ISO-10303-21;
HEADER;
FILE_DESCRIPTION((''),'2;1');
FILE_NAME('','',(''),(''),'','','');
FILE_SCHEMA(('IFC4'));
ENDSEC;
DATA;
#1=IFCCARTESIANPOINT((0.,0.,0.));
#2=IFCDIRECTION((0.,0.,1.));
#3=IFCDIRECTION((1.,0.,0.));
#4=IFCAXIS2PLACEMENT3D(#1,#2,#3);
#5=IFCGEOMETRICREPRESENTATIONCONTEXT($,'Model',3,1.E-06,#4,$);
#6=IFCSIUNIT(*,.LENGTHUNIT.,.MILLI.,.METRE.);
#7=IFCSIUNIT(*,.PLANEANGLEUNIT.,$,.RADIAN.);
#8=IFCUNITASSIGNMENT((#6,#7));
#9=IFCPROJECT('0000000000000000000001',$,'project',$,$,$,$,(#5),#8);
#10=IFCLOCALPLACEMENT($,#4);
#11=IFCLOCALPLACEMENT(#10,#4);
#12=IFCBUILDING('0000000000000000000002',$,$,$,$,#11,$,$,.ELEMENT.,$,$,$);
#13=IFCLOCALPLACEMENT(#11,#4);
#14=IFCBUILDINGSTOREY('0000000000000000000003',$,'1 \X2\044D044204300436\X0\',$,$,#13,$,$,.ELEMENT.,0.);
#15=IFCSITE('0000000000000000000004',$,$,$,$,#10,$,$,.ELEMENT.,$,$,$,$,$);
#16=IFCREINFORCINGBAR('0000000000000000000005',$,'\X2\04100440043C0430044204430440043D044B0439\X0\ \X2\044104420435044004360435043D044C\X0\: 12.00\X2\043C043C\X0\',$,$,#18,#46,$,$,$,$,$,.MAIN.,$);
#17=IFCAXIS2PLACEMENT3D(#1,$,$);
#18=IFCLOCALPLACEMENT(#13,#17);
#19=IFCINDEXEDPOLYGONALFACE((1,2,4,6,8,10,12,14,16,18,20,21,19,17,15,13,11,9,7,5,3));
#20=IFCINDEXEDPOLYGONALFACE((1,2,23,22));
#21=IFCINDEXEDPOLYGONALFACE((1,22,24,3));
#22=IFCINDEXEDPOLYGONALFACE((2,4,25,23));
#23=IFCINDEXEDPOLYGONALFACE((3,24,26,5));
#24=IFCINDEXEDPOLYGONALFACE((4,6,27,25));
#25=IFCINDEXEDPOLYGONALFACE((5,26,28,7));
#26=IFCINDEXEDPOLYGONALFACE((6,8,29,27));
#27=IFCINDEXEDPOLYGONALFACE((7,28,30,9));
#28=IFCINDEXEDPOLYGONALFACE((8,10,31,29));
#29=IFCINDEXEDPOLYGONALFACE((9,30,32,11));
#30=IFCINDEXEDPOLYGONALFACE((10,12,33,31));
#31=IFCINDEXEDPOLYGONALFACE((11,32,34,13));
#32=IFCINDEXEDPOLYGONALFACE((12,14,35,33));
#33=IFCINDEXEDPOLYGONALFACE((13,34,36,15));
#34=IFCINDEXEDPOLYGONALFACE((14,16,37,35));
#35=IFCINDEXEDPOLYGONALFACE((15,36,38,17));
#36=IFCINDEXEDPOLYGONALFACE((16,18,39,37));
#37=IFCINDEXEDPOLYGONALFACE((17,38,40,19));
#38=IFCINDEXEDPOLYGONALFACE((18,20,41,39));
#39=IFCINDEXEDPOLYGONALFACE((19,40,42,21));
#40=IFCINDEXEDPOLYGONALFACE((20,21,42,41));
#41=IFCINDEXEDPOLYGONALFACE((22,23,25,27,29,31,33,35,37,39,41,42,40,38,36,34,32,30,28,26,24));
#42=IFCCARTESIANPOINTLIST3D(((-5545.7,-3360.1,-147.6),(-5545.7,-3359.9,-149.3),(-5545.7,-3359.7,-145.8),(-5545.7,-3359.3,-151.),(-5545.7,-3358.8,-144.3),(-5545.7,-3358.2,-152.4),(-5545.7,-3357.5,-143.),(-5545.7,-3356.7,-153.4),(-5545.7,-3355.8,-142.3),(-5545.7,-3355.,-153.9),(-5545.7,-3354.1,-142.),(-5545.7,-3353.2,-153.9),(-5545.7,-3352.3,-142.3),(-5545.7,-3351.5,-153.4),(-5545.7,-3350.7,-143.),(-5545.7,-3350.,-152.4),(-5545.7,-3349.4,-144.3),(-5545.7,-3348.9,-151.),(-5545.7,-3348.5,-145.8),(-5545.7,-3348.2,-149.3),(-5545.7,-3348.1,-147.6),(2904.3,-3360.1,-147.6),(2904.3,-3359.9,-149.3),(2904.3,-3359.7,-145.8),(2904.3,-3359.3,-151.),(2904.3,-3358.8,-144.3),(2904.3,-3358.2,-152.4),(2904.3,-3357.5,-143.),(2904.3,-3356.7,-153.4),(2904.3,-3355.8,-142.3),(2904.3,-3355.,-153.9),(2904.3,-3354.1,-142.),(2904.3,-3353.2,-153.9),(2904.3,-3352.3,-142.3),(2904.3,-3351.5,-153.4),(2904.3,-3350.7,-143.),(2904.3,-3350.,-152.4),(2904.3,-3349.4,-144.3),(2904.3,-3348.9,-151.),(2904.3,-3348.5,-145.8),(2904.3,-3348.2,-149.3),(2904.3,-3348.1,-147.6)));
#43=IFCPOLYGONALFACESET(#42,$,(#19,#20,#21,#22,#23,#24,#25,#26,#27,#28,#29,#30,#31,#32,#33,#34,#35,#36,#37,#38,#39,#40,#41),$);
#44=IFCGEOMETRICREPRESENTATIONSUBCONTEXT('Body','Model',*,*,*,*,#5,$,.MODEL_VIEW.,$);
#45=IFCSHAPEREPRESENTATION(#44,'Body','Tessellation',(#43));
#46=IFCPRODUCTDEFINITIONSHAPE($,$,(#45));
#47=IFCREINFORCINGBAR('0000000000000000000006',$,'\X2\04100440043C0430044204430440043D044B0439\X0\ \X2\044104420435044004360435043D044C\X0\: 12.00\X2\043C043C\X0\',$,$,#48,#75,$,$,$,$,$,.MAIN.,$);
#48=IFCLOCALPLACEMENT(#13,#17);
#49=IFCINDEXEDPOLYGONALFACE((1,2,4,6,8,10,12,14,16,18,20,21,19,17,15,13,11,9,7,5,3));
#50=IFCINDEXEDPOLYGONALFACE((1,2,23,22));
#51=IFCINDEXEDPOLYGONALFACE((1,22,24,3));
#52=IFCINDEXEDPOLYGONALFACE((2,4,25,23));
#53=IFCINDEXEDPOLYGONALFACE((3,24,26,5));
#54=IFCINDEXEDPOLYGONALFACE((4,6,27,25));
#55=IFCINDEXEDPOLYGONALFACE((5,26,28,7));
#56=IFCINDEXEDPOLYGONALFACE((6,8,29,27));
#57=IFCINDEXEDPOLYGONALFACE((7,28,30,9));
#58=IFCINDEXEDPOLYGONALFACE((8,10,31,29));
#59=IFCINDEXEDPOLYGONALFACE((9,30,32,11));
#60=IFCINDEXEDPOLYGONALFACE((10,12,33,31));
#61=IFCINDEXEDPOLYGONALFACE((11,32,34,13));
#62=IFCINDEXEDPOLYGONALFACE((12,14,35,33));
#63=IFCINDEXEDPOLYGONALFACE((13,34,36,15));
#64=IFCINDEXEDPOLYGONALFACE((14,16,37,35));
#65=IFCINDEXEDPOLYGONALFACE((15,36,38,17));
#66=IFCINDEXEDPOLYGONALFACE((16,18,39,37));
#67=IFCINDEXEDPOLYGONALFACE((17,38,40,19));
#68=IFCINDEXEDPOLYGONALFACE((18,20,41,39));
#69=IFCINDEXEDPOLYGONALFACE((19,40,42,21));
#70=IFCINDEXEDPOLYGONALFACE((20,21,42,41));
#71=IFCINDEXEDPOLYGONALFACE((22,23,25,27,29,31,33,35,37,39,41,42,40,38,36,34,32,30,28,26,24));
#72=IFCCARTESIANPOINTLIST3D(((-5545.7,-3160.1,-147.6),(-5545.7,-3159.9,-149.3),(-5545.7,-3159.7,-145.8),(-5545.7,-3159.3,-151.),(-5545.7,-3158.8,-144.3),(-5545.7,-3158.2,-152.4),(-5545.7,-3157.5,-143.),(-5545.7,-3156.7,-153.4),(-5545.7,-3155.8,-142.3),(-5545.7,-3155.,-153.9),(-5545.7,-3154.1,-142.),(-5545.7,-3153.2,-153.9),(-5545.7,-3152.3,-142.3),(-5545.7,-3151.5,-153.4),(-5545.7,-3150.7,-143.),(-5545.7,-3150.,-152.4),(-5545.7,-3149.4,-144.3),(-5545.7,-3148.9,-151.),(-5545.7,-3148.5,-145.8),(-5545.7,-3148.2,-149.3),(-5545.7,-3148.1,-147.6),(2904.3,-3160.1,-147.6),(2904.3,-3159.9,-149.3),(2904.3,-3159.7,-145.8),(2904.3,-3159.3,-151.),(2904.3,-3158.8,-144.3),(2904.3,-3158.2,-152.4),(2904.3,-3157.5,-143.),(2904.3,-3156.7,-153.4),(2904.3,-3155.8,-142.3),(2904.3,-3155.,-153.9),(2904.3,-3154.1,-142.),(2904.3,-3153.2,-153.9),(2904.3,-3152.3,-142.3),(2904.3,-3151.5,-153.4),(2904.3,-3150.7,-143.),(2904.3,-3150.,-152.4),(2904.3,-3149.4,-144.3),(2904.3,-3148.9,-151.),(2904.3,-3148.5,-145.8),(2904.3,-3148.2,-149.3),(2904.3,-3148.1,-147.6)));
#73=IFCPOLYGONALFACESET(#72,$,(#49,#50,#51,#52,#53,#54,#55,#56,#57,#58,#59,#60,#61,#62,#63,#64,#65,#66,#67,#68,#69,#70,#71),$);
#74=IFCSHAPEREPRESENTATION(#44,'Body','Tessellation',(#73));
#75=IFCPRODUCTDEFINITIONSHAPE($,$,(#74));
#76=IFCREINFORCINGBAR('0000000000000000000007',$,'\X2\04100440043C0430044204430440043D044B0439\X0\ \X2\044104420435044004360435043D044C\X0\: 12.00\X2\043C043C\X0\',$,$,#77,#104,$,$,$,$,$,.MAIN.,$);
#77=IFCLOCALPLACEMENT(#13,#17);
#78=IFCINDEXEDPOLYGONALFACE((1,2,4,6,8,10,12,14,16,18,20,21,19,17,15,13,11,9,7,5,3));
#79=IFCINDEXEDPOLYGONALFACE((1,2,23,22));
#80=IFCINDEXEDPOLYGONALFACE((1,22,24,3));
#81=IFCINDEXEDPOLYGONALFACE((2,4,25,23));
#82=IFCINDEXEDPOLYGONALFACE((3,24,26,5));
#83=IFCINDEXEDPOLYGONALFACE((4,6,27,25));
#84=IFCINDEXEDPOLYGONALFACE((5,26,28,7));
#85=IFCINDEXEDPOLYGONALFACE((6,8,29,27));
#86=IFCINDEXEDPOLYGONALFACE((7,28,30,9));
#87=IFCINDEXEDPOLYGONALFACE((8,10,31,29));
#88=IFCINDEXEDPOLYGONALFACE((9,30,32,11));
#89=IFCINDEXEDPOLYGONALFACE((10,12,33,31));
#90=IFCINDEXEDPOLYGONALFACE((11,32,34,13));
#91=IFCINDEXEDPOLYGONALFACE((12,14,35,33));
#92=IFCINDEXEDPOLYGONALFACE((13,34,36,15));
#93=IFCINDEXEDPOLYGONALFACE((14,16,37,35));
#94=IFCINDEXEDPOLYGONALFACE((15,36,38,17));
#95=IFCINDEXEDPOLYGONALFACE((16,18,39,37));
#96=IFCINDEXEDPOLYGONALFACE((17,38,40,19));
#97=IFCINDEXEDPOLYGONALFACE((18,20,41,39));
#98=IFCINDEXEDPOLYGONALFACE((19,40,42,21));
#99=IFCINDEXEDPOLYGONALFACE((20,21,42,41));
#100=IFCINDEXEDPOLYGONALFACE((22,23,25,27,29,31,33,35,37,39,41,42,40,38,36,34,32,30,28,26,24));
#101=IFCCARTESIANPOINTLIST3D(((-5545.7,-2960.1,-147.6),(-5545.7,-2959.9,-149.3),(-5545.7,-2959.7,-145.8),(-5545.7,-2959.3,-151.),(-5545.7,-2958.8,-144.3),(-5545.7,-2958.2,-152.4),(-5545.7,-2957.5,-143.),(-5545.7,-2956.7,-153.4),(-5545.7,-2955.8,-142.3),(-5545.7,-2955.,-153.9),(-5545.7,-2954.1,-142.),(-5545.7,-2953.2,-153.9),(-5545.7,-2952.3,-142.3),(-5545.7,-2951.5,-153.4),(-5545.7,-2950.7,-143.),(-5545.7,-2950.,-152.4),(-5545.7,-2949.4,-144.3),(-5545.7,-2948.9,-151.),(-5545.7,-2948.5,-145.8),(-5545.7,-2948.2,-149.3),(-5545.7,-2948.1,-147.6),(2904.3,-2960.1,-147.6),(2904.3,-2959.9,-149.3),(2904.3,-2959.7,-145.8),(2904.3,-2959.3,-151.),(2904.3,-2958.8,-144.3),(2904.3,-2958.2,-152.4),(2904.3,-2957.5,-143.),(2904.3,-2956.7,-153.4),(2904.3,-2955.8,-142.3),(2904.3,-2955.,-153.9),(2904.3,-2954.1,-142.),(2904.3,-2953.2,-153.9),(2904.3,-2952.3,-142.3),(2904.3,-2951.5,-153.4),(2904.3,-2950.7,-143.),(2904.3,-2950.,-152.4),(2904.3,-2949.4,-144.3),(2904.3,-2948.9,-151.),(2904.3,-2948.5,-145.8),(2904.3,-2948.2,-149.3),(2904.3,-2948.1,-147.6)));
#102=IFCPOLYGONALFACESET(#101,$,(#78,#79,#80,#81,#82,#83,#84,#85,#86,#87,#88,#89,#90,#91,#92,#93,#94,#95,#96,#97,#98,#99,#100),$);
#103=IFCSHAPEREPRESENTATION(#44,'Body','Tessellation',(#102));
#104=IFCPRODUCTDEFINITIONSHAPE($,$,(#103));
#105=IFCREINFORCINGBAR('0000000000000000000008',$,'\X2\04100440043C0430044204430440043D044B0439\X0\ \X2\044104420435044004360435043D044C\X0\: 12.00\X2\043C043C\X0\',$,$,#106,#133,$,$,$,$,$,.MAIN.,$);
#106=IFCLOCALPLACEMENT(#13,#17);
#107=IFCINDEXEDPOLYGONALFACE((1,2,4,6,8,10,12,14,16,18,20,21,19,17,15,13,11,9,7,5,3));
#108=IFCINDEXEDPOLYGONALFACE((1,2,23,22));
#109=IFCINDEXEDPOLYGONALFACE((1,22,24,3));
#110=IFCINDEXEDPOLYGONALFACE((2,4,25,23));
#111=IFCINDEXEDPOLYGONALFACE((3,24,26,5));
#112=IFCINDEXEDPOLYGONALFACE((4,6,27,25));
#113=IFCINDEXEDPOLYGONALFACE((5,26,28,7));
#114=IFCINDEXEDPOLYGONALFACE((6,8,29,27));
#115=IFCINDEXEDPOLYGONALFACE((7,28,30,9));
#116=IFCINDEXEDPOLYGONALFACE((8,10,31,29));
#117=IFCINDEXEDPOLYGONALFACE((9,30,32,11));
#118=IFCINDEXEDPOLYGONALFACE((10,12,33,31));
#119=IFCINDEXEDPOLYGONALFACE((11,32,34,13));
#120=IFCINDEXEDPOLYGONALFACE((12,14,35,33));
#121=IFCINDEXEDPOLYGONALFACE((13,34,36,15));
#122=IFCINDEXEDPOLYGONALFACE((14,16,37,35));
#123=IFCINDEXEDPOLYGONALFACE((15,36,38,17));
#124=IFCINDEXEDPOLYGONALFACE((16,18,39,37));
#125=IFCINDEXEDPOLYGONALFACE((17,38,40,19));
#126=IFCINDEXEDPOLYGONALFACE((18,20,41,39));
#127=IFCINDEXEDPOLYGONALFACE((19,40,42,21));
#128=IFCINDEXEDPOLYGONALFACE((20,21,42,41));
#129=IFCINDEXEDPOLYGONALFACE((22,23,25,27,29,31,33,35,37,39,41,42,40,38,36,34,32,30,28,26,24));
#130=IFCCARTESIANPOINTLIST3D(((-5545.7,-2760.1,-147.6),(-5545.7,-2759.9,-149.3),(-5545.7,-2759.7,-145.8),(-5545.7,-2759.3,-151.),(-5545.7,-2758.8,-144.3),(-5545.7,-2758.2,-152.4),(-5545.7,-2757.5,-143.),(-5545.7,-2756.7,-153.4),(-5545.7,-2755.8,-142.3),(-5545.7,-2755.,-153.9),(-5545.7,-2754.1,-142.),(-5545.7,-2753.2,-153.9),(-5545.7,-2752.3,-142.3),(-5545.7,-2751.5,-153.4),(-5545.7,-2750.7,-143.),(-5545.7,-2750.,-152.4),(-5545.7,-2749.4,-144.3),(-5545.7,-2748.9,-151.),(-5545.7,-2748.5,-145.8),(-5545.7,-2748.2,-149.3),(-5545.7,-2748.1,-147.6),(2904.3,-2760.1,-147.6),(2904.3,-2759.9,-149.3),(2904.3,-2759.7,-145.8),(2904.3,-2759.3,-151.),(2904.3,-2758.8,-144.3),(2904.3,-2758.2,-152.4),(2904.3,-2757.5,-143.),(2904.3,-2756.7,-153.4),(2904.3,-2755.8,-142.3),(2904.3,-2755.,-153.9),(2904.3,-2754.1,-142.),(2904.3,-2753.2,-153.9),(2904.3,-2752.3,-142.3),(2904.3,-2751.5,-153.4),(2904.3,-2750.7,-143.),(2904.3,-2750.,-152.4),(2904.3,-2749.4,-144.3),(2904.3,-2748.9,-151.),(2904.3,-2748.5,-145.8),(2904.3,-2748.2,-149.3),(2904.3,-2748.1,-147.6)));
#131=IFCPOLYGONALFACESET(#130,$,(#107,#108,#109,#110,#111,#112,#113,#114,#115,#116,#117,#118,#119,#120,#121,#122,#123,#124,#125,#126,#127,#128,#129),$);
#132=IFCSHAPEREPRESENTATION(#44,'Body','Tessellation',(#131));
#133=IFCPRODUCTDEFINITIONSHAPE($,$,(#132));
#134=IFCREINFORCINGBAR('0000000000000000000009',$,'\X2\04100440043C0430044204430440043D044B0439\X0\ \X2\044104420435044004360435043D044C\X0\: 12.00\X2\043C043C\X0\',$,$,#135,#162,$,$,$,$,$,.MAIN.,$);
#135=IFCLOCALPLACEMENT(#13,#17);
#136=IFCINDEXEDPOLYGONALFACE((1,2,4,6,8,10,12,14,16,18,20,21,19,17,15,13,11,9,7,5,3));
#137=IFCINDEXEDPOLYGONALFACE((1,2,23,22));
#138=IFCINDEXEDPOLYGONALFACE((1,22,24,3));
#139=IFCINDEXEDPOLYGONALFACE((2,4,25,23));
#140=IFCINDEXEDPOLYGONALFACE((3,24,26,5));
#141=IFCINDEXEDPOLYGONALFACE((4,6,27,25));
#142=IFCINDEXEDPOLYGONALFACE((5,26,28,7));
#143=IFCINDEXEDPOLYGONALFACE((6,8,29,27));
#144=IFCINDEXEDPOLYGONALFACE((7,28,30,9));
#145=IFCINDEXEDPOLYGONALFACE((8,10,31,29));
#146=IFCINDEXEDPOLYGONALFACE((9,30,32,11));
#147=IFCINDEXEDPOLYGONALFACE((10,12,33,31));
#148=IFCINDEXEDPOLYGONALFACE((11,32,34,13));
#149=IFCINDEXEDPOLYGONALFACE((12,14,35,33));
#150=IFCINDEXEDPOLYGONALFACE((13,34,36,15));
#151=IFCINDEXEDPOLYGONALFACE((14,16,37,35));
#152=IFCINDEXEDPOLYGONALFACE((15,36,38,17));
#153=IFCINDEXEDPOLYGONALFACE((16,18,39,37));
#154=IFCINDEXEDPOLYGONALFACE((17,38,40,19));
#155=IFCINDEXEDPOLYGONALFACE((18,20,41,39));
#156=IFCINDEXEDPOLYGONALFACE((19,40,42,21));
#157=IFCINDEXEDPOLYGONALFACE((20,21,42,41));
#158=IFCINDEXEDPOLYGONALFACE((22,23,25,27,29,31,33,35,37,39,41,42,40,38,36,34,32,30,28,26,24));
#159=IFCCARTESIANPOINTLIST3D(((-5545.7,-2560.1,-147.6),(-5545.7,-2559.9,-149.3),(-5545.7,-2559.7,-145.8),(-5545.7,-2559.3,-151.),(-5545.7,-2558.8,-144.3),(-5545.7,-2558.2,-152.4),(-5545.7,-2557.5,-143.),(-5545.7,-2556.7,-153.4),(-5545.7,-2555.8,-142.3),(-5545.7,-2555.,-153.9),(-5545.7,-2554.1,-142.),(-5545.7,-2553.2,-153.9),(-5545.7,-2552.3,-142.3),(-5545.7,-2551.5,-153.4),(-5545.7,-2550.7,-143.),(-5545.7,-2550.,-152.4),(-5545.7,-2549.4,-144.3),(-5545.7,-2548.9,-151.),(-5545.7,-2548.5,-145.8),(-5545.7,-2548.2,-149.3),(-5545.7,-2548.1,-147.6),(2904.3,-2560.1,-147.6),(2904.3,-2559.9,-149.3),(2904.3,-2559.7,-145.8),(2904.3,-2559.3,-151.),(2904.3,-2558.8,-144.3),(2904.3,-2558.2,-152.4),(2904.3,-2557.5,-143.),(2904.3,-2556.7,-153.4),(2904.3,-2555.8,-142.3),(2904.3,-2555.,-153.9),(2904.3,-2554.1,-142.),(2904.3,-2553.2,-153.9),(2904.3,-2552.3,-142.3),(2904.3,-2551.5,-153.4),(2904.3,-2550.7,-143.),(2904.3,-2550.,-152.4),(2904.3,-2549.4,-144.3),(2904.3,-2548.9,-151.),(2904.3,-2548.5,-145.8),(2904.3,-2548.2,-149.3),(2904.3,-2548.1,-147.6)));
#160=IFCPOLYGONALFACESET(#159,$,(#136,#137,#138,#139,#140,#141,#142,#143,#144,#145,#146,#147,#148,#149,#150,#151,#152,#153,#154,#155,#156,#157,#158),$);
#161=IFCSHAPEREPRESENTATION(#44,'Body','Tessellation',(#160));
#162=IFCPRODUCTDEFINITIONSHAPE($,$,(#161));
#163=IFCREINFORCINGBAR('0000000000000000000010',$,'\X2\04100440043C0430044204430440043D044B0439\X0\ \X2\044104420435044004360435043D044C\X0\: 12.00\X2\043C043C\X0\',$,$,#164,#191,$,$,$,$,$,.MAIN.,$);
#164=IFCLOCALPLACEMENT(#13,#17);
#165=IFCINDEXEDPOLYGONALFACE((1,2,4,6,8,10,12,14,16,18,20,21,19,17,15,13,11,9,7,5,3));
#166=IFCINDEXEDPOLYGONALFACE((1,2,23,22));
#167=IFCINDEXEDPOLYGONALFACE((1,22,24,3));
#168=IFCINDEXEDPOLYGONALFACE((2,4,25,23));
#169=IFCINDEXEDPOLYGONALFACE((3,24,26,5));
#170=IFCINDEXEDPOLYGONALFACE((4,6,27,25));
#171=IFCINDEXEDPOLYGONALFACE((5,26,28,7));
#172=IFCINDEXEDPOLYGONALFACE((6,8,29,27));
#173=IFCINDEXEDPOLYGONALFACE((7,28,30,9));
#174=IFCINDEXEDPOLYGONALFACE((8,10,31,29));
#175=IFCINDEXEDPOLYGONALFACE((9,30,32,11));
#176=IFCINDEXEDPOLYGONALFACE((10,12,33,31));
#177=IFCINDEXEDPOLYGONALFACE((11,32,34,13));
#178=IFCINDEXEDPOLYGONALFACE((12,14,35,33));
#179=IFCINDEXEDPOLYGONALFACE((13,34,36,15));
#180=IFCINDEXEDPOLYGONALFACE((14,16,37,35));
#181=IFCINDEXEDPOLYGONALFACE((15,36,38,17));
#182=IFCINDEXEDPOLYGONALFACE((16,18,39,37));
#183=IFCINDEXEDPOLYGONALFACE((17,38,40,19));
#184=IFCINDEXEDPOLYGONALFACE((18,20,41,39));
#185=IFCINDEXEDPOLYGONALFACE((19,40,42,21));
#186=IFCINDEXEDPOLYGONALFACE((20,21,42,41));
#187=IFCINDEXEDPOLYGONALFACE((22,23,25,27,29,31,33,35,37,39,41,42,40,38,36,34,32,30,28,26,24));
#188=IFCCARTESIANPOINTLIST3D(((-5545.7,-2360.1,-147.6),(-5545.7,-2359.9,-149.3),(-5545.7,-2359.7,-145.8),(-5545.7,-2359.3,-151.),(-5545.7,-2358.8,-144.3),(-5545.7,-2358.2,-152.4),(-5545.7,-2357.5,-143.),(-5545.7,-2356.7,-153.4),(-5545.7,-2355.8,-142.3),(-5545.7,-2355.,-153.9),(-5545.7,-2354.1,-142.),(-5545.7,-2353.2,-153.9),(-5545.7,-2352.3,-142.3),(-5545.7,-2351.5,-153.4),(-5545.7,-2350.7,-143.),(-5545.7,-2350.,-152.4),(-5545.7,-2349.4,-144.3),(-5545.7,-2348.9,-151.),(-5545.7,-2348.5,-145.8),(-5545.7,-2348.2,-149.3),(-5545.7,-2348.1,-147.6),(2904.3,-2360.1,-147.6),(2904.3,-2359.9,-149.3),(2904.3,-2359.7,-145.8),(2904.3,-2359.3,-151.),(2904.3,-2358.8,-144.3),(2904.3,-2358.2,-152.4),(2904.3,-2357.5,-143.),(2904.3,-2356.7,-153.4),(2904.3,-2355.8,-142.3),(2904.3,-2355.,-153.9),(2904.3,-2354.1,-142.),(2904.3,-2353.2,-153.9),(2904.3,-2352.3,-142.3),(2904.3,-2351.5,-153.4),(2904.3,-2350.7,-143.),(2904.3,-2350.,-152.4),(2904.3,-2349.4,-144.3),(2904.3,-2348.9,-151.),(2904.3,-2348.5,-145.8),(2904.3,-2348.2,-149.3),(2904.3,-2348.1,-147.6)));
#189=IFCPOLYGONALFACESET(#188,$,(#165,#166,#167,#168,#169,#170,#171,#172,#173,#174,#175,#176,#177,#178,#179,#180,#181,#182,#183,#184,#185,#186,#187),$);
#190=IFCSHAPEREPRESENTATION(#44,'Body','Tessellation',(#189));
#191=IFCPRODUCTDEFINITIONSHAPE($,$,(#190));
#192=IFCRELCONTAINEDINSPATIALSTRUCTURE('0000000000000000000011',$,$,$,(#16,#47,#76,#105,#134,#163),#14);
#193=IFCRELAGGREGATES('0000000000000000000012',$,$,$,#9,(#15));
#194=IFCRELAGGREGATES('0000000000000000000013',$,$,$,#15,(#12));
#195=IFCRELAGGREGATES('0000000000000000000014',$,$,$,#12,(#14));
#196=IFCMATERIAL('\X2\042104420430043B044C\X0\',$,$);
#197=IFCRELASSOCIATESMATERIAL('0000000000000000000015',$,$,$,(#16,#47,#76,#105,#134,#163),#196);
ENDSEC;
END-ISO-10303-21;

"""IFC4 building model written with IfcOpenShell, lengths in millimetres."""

from ifc_helpers import new_model, entity, si_unit, origin_with_axes, place, context, subcontext, project, spatial, source, transform, mapped, material, element, save


model = new_model("IFC4")

# Units and contexts
model_context = context("Model", 3, precision=1e-06, world=origin_with_axes())
body_context = subcontext(model_context, "Body", "Model", "MODEL_VIEW")
ifc_project = project(units=[si_unit("LENGTHUNIT", "METRE", prefix="MILLI"), si_unit("PLANEANGLEUNIT", "RADIAN")], contexts=[model_context])

# Site, building, storey
site_placement = place(None, origin_with_axes())
site = spatial("IfcSite", under=ifc_project, at=site_placement, CompositionType="ELEMENT")
building_placement = place(site_placement, origin_with_axes())
building = spatial("IfcBuilding", under=site, at=building_placement, CompositionType="ELEMENT")
storey_placement = place(building_placement, origin_with_axes())
storey = spatial("IfcBuildingStorey", under=building, at=storey_placement, Name="1 этаж", CompositionType="ELEMENT", Elevation=0.0)

# Shared definitions
ifc_material_1 = material(Name="Сталь")

# Reinforcing bars
shared_shape_1 = source(origin_with_axes(), body_context, "Body", "AdvancedSweptSolid", [
    entity("IfcSweptDiskSolid", entity("IfcIndexedPolyCurve", entity("IfcCartesianPointList3D", [[0.0, 0.0, 0.0], [8450.0, 0.0, 0.0]]), [entity("IfcLineIndex", [1, 2])]), 6.0),
])
reinforcing_bar_1_placement = place(storey_placement, origin_with_axes())
element("IfcReinforcingBar", 1, at=reinforcing_bar_1_placement, inside=storey, material=ifc_material_1, Name="Арматурный стержень: 12.00мм", PredefinedType="MAIN", context=body_context, shape_type="MappedRepresentation", body=[
    mapped(shared_shape_1, transform((-5545.7, -3354.1, -148.0), x_axis=(1.0, 0.0, 0.0), y_axis=(0.0, 1.0, 0.0), z_axis=(0.0, 0.0, 1.0), scale=1.0)),
])
reinforcing_bar_2_placement = place(storey_placement, origin_with_axes())
element("IfcReinforcingBar", 2, at=reinforcing_bar_2_placement, inside=storey, material=ifc_material_1, Name="Арматурный стержень: 12.00мм", PredefinedType="MAIN", context=body_context, shape_type="MappedRepresentation", body=[
    mapped(shared_shape_1, transform((-5545.7, -3154.1, -148.0), x_axis=(1.0, 0.0, 0.0), y_axis=(0.0, 1.0, 0.0), z_axis=(0.0, 0.0, 1.0), scale=1.0)),
])
reinforcing_bar_3_placement = place(storey_placement, origin_with_axes())
element("IfcReinforcingBar", 3, at=reinforcing_bar_3_placement, inside=storey, material=ifc_material_1, Name="Арматурный стержень: 12.00мм", PredefinedType="MAIN", context=body_context, shape_type="MappedRepresentation", body=[
    mapped(shared_shape_1, transform((-5545.7, -2954.1, -148.0), x_axis=(1.0, 0.0, 0.0), y_axis=(0.0, 1.0, 0.0), z_axis=(0.0, 0.0, 1.0), scale=1.0)),
])
reinforcing_bar_4_placement = place(storey_placement, origin_with_axes())
element("IfcReinforcingBar", 4, at=reinforcing_bar_4_placement, inside=storey, material=ifc_material_1, Name="Арматурный стержень: 12.00мм", PredefinedType="MAIN", context=body_context, shape_type="MappedRepresentation", body=[
    mapped(shared_shape_1, transform((-5545.7, -2754.1, -148.0), x_axis=(1.0, 0.0, 0.0), y_axis=(0.0, 1.0, 0.0), z_axis=(0.0, 0.0, 1.0), scale=1.0)),
])
reinforcing_bar_5_placement = place(storey_placement, origin_with_axes())
element("IfcReinforcingBar", 5, at=reinforcing_bar_5_placement, inside=storey, material=ifc_material_1, Name="Арматурный стержень: 12.00мм", PredefinedType="MAIN", context=body_context, shape_type="MappedRepresentation", body=[
    mapped(shared_shape_1, transform((-5545.7, -2554.1, -148.0), x_axis=(1.0, 0.0, 0.0), y_axis=(0.0, 1.0, 0.0), z_axis=(0.0, 0.0, 1.0), scale=1.0)),
])
reinforcing_bar_6_placement = place(storey_placement, origin_with_axes())
element("IfcReinforcingBar", 6, at=reinforcing_bar_6_placement, inside=storey, material=ifc_material_1, Name="Арматурный стержень: 12.00мм", PredefinedType="MAIN", context=body_context, shape_type="MappedRepresentation", body=[
    mapped(shared_shape_1, transform((-5545.7, -2354.1, -148.0), x_axis=(1.0, 0.0, 0.0), y_axis=(0.0, 1.0, 0.0), z_axis=(0.0, 0.0, 1.0), scale=1.0)),
])

save(model, "model.ifc")
